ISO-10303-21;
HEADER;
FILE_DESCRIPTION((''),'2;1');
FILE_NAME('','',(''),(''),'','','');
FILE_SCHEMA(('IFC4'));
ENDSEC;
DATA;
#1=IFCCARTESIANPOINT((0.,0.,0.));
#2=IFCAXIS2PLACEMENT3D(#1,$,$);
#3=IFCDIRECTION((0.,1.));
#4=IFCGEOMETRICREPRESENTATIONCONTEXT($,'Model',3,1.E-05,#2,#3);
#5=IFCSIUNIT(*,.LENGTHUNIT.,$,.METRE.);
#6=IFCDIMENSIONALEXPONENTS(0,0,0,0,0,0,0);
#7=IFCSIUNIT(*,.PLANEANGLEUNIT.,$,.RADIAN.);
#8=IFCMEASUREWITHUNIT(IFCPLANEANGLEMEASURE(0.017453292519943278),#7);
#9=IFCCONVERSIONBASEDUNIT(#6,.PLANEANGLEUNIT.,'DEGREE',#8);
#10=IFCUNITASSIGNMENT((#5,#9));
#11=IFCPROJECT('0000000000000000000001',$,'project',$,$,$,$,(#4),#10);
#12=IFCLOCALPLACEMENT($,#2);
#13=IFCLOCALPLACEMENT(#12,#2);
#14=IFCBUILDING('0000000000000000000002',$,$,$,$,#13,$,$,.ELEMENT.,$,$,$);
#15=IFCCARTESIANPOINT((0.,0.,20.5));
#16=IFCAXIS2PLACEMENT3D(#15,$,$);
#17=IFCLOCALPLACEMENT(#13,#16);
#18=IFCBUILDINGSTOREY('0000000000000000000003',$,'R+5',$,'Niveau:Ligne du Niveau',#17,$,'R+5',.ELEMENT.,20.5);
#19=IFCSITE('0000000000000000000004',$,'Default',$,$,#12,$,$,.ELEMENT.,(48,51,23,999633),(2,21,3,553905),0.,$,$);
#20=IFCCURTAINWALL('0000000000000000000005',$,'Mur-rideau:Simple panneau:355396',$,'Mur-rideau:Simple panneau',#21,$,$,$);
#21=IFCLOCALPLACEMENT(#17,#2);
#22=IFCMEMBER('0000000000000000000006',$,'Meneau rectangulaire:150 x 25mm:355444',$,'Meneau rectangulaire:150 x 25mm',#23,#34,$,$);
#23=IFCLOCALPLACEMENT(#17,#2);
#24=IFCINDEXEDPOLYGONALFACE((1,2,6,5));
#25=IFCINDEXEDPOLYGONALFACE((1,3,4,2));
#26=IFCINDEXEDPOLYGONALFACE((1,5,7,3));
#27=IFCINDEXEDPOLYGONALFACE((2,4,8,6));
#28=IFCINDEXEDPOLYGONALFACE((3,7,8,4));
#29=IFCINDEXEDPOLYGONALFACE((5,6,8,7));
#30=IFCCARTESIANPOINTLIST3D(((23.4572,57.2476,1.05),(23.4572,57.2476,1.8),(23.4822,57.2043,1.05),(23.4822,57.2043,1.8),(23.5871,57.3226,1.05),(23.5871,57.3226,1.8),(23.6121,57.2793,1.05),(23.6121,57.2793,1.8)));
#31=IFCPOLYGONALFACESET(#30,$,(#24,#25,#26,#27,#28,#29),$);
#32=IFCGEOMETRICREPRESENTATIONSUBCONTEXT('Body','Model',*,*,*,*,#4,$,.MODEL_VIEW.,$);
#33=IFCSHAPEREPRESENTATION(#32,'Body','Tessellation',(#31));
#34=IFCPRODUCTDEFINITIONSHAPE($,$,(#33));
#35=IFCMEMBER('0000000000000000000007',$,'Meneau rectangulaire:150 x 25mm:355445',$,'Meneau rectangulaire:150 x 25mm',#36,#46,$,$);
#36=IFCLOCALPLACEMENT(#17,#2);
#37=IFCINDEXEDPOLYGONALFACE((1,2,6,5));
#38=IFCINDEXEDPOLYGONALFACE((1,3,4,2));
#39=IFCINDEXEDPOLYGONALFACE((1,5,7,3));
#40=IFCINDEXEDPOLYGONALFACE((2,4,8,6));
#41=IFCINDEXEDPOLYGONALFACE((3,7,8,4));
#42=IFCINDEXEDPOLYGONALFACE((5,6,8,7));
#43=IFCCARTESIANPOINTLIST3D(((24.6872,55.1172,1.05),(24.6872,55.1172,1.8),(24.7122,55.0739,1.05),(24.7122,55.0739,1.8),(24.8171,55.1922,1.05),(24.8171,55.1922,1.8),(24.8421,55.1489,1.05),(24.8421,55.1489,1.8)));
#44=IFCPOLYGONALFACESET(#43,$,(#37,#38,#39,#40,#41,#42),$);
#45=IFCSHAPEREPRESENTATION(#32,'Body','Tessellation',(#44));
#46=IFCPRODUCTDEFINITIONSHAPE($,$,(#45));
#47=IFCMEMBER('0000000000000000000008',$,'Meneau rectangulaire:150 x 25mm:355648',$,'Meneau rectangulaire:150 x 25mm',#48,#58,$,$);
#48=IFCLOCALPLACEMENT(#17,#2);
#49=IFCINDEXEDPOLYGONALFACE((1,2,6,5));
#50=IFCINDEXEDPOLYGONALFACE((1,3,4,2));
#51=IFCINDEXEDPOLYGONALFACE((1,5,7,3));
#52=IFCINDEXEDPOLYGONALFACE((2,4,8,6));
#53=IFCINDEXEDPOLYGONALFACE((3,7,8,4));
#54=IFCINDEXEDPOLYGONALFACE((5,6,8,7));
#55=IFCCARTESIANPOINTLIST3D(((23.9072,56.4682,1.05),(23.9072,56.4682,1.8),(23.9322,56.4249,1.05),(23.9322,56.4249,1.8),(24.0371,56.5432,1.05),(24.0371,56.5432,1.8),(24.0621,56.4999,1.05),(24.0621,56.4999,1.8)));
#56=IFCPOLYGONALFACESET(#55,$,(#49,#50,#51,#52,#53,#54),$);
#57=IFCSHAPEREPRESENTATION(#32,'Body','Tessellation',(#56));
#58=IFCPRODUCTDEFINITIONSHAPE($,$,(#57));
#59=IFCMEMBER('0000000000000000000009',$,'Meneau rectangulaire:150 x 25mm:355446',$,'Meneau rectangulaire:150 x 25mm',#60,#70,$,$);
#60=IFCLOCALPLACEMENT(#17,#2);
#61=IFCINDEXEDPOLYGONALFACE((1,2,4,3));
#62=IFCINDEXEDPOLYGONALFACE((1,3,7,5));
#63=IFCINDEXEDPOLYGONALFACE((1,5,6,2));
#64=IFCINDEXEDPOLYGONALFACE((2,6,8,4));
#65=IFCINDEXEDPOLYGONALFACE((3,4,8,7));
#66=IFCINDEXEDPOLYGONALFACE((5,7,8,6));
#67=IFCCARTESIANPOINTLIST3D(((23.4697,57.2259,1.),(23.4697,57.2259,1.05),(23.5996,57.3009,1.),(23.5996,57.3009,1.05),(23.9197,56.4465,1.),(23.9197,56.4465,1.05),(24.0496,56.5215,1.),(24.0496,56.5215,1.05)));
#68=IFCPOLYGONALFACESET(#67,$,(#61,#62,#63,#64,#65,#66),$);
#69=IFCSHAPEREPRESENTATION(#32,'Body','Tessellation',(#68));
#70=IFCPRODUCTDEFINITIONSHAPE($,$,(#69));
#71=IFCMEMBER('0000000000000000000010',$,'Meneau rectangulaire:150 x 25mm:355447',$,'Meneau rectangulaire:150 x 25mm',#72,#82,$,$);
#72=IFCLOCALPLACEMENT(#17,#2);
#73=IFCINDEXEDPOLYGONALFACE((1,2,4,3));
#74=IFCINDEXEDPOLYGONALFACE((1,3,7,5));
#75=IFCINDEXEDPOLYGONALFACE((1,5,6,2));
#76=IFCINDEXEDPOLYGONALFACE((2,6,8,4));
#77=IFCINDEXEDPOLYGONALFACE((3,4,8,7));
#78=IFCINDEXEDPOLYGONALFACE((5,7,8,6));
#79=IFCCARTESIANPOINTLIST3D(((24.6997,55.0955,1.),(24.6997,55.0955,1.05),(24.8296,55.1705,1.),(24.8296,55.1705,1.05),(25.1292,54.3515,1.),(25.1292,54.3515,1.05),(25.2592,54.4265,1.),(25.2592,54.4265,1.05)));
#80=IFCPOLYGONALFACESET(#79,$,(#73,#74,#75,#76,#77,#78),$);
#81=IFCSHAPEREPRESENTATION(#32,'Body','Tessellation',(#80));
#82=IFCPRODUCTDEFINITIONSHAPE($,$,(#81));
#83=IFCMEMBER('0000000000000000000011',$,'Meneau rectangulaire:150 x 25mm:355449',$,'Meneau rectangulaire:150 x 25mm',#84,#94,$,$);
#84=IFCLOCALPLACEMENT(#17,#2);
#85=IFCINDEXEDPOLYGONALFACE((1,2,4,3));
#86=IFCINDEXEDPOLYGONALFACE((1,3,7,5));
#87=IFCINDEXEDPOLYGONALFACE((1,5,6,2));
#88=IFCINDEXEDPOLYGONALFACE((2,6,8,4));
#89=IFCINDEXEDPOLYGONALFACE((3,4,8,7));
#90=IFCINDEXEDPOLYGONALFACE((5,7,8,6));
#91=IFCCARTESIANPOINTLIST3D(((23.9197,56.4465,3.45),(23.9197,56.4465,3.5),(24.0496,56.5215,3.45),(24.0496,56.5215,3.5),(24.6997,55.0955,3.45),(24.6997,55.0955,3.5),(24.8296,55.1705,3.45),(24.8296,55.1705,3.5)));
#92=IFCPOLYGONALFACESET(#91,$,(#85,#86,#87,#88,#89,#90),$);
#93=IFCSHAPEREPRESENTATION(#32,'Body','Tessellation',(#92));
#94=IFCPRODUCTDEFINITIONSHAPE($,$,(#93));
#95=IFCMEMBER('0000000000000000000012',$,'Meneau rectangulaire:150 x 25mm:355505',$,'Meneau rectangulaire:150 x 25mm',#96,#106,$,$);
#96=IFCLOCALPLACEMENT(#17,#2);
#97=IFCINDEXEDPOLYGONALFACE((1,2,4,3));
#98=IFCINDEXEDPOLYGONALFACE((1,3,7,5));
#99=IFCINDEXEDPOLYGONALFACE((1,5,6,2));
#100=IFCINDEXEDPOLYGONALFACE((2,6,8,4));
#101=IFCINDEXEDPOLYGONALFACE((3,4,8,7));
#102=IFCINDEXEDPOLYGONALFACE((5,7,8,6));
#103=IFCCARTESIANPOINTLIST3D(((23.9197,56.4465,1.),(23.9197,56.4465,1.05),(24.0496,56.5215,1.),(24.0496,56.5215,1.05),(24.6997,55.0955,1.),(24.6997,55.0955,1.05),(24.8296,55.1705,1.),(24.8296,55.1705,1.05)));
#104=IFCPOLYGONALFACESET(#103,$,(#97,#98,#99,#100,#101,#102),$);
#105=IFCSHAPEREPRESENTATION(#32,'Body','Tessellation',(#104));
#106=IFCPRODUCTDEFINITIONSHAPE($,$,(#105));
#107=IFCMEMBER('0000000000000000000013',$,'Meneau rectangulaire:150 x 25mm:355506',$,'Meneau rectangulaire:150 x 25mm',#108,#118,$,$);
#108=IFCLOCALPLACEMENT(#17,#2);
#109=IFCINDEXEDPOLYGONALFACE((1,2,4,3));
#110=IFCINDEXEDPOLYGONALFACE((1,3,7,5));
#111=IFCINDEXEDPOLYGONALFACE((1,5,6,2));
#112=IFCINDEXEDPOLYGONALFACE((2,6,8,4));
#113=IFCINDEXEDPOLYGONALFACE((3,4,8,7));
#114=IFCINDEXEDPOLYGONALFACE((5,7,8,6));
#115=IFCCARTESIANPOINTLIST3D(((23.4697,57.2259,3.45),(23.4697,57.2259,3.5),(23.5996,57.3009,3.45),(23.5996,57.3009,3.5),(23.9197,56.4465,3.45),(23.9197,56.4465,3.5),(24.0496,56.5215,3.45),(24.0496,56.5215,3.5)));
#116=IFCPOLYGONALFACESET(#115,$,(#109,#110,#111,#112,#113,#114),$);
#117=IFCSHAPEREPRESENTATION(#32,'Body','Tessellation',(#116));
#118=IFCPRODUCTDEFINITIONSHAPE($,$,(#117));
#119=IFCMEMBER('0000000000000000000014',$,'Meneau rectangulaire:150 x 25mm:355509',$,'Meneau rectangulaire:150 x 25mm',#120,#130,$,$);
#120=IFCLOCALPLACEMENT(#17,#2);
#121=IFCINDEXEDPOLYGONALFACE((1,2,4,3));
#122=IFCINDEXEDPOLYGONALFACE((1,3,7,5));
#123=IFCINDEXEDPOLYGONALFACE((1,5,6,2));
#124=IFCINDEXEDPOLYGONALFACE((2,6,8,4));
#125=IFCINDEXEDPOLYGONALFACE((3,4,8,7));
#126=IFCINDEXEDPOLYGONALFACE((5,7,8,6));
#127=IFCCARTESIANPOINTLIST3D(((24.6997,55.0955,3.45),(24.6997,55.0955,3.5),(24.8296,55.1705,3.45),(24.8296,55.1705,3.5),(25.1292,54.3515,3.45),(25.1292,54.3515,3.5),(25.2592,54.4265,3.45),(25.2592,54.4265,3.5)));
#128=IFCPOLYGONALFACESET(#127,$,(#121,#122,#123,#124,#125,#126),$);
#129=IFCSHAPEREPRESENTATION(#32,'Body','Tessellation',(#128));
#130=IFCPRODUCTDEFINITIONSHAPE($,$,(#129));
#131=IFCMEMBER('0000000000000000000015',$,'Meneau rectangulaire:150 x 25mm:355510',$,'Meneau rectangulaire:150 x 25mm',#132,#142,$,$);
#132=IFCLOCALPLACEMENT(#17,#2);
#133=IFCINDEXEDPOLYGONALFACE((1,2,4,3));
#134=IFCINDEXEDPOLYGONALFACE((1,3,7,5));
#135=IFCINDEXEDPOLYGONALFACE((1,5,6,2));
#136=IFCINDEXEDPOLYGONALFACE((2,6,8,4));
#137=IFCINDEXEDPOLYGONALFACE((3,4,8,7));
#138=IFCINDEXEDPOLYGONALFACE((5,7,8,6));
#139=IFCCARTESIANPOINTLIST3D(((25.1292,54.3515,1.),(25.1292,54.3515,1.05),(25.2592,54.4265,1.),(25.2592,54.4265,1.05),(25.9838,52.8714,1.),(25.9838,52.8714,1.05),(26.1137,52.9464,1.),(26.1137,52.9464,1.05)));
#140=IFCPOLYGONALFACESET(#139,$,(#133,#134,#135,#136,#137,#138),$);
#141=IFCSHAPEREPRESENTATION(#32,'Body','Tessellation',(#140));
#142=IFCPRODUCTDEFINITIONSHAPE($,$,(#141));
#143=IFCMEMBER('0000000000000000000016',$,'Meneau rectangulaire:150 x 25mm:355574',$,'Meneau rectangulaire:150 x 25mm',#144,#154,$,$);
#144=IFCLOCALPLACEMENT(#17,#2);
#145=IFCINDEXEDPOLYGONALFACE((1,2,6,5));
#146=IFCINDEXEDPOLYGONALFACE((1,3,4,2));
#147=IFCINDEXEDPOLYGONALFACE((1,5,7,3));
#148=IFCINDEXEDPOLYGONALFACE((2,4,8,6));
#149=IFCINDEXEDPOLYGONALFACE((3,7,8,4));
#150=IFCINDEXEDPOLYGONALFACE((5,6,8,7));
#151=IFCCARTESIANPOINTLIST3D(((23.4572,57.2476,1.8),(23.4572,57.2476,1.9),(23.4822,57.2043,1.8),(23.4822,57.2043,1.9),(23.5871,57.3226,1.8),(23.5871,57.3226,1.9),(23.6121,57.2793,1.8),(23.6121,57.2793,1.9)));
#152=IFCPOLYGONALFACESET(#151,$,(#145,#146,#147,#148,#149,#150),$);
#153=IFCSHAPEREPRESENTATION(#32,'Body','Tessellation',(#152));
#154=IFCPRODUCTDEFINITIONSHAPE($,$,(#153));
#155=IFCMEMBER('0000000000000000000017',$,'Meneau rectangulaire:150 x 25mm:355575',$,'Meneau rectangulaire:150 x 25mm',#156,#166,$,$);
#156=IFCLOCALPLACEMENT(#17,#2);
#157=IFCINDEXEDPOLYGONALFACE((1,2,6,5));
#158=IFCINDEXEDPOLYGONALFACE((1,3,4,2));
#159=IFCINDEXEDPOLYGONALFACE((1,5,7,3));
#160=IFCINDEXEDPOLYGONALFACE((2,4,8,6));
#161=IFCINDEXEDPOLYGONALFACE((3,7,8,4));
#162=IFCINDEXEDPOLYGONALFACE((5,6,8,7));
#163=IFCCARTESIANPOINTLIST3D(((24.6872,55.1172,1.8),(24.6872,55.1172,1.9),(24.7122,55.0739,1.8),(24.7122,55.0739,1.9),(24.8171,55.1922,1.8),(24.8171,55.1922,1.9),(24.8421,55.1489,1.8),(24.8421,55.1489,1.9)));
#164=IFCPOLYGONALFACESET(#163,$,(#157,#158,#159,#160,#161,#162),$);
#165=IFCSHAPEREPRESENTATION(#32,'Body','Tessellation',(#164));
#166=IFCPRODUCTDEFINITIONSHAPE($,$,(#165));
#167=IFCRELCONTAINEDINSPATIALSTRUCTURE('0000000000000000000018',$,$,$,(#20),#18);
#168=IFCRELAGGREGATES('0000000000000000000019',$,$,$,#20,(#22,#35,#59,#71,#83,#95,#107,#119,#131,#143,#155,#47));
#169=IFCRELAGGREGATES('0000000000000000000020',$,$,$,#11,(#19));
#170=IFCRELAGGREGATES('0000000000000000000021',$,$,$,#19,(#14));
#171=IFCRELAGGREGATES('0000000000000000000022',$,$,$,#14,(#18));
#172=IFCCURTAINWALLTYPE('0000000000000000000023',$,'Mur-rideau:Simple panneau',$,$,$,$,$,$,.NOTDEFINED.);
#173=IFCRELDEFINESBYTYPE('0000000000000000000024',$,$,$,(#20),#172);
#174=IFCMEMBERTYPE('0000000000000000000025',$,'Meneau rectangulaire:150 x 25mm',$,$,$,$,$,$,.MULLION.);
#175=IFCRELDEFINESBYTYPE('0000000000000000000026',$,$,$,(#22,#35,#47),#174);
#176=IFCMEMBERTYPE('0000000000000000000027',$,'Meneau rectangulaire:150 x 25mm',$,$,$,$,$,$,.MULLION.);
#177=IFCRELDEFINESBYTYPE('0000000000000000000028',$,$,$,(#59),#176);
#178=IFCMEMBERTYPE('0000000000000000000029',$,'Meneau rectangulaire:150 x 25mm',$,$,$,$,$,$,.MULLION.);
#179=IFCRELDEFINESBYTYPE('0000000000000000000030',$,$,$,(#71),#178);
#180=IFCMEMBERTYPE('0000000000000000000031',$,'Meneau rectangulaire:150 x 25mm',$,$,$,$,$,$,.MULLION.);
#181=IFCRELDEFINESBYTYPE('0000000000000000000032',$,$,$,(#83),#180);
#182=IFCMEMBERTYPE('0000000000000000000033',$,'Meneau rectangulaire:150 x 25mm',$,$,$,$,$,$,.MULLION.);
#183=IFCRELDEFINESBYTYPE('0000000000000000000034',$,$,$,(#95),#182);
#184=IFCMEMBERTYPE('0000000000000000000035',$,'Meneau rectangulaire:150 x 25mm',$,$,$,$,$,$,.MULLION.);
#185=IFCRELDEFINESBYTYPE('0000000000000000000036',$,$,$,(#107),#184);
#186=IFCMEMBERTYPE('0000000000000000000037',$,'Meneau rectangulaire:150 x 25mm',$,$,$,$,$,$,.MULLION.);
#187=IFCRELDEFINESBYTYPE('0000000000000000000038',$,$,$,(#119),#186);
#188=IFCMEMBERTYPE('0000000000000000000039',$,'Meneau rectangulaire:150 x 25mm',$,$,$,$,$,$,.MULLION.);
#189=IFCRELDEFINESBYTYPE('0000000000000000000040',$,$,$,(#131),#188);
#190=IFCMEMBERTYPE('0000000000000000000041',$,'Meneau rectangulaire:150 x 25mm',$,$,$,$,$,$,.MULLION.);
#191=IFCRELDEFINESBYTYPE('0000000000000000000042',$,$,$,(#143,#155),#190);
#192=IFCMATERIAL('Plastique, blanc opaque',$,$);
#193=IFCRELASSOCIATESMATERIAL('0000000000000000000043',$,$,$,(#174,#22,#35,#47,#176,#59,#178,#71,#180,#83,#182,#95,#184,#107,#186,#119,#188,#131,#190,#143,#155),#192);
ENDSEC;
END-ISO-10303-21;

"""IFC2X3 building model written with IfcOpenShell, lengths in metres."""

from ifc_helpers import new_model, entity, si_unit, converted_unit, direction, frame, origin, origin_2d_with_axis, place, context, subcontext, project, spatial, rectangle, extrude, source, transform, mapped, material, type_object, type_shapes, element, aggregate, save


model = new_model("IFC2X3")

# Units and contexts
model_context = context("Model", 3, precision=1e-05, world=origin(), true_north=direction((0.0, 1.0)))
body_context = subcontext(model_context, "Body", "Model", "MODEL_VIEW")
ifc_project = project(units=[si_unit("LENGTHUNIT", "METRE"), converted_unit("PLANEANGLEUNIT", "DEGREE", entity("IfcPlaneAngleMeasure", 0.017453292519943278), si_unit("PLANEANGLEUNIT", "RADIAN"), dimensions=[0, 0, 0, 0, 0, 0, 0])], contexts=[model_context])

# Site, building, storey
site_placement = place(None, origin())
site = spatial("IfcSite", under=ifc_project, at=site_placement, Name="Default", CompositionType="ELEMENT", RefLatitude=(48, 51, 23, 999633), RefLongitude=(2, 21, 3, 553905), RefElevation=0.0)
building_placement = place(site_placement, origin())
building = spatial("IfcBuilding", under=site, at=building_placement, CompositionType="ELEMENT")
storey_placement = place(building_placement, frame((0.0, 0.0, 20.5)))
storey = spatial("IfcBuildingStorey", under=building, at=storey_placement, Name="R+5", ObjectType="Niveau:Ligne du Niveau", LongName="R+5", CompositionType="ELEMENT", Elevation=20.5)

# Curtain wall, members
curtain_wall_type = type_object("IfcCurtainWallType", Name="Mur-rideau:Simple panneau", PredefinedType="NOTDEFINED")
curtain_wall_placement = place(storey_placement, frame((0.0, 0.0, -20.5)))
curtain_wall = element("IfcCurtainWall", 1, at=curtain_wall_placement, inside=storey, type_object=curtain_wall_type, Name="Mur-rideau:Simple panneau:355396", ObjectType="Mur-rideau:Simple panneau")
ifc_material_1 = material(Name="Plastique, blanc opaque")
member_type_1 = type_object("IfcMemberType", Name="Meneau rectangulaire:150 x 25mm", PredefinedType="MULLION", material=ifc_material_1)
shared_shape_1 = source(origin(), body_context, "Body", "SweptSolid", [
    extrude(rectangle(XDim=0.05, YDim=0.15, at=origin_2d_with_axis()), frame((0.0, 0.0, -0.75), z_axis=(0.0, 0.0, 1.0), x_axis=(-1.0, 0.0, 0.0)), (0.0, 0.0, 1.0), 0.75),
])
type_shapes(member_type_1, [shared_shape_1])
member_1_placement = place(curtain_wall_placement, frame((23.5346, 57.2634, 21.55), z_axis=(0.0, 0.0, -1.0), x_axis=(0.5, -0.866025, 0.0)))
member_1 = element("IfcMember", 2, at=member_1_placement, type_object=member_type_1, material=ifc_material_1, Name="Meneau rectangulaire:150 x 25mm:355444", ObjectType="Meneau rectangulaire:150 x 25mm", context=body_context, shape_type="MappedRepresentation", body=[
    mapped(shared_shape_1, transform((0.0, 0.0, 0.0), scale=1.0)),
])
member_2_placement = place(curtain_wall_placement, frame((24.7646, 55.133, 21.55), z_axis=(0.0, 0.0, -1.0), x_axis=(0.5, -0.866025, 0.0)))
member_2 = element("IfcMember", 3, at=member_2_placement, type_object=member_type_1, material=ifc_material_1, Name="Meneau rectangulaire:150 x 25mm:355445", ObjectType="Meneau rectangulaire:150 x 25mm", context=body_context, shape_type="MappedRepresentation", body=[
    mapped(shared_shape_1, transform((0.0, 0.0, 0.0), scale=1.0)),
])
member_3_placement = place(curtain_wall_placement, frame((23.9846, 56.484, 21.55), z_axis=(0.0, 0.0, -1.0), x_axis=(0.5, -0.866025, 0.0)))
member_3 = element("IfcMember", 4, at=member_3_placement, type_object=member_type_1, material=ifc_material_1, Name="Meneau rectangulaire:150 x 25mm:355648", ObjectType="Meneau rectangulaire:150 x 25mm", context=body_context, shape_type="MappedRepresentation", body=[
    mapped(shared_shape_1, transform((0.0, 0.0, 0.0), scale=1.0)),
])
member_type_2 = type_object("IfcMemberType", Name="Meneau rectangulaire:150 x 25mm", PredefinedType="MULLION", material=ifc_material_1)
shared_shape_2 = source(origin(), body_context, "Body", "SweptSolid", [
    extrude(rectangle(XDim=0.05, YDim=0.15, at=origin_2d_with_axis()), frame((-0.025, 0.0, -0.9), z_axis=(0.0, 0.0, 1.0), x_axis=(-1.0, 0.0, 0.0)), (0.0, 0.0, 1.0), 0.9),
])
type_shapes(member_type_2, [shared_shape_2])
member_4_placement = place(curtain_wall_placement, frame((23.5346, 57.2634, 21.5), z_axis=(-0.5, 0.866025, 0.0), x_axis=(0.0, 0.0, -1.0)))
member_4 = element("IfcMember", 5, at=member_4_placement, type_object=member_type_2, material=ifc_material_1, Name="Meneau rectangulaire:150 x 25mm:355446", ObjectType="Meneau rectangulaire:150 x 25mm", context=body_context, shape_type="MappedRepresentation", body=[
    mapped(shared_shape_2, transform((0.0, 0.0, 0.0), scale=1.0)),
])
member_type_3 = type_object("IfcMemberType", Name="Meneau rectangulaire:150 x 25mm", PredefinedType="MULLION", material=ifc_material_1)
shared_shape_3 = source(origin(), body_context, "Body", "SweptSolid", [
    extrude(rectangle(XDim=0.05, YDim=0.15, at=origin_2d_with_axis()), frame((-0.025, 0.0, -0.8591), z_axis=(0.0, 0.0, 1.0), x_axis=(-1.0, 0.0, 0.0)), (0.0, 0.0, 1.0), 0.8591),
])
type_shapes(member_type_3, [shared_shape_3])
member_5_placement = place(curtain_wall_placement, frame((24.7646, 55.133, 21.5), z_axis=(-0.5, 0.866025, 0.0), x_axis=(0.0, 0.0, -1.0)))
member_5 = element("IfcMember", 6, at=member_5_placement, type_object=member_type_3, material=ifc_material_1, Name="Meneau rectangulaire:150 x 25mm:355447", ObjectType="Meneau rectangulaire:150 x 25mm", context=body_context, shape_type="MappedRepresentation", body=[
    mapped(shared_shape_3, transform((0.0, 0.0, 0.0), scale=1.0)),
])
member_type_4 = type_object("IfcMemberType", Name="Meneau rectangulaire:150 x 25mm", PredefinedType="MULLION", material=ifc_material_1)
shared_shape_4 = source(origin(), body_context, "Body", "SweptSolid", [
    extrude(rectangle(XDim=0.05, YDim=0.15, at=origin_2d_with_axis()), frame((-0.025, 0.0, -1.56), z_axis=(0.0, 0.0, 1.0), x_axis=(-1.0, 0.0, 0.0)), (0.0, 0.0, 1.0), 1.56),
])
type_shapes(member_type_4, [shared_shape_4])
member_6_placement = place(curtain_wall_placement, frame((24.7646, 55.133, 24.0), z_axis=(0.5, -0.866025, 0.0), x_axis=(0.0, 0.0, 1.0)))
member_6 = element("IfcMember", 7, at=member_6_placement, type_object=member_type_4, material=ifc_material_1, Name="Meneau rectangulaire:150 x 25mm:355449", ObjectType="Meneau rectangulaire:150 x 25mm", context=body_context, shape_type="MappedRepresentation", body=[
    mapped(shared_shape_4, transform((0.0, 0.0, 0.0), scale=1.0)),
])
member_type_5 = type_object("IfcMemberType", Name="Meneau rectangulaire:150 x 25mm", PredefinedType="MULLION", material=ifc_material_1)
shared_shape_5 = source(origin(), body_context, "Body", "SweptSolid", [
    extrude(rectangle(XDim=0.05, YDim=0.15, at=origin_2d_with_axis()), frame((-0.025, 0.0, -1.56), z_axis=(0.0, 0.0, 1.0), x_axis=(-1.0, 0.0, 0.0)), (0.0, 0.0, 1.0), 1.56),
])
type_shapes(member_type_5, [shared_shape_5])
member_7_placement = place(curtain_wall_placement, frame((23.9846, 56.484, 21.5), z_axis=(-0.5, 0.866025, 0.0), x_axis=(0.0, 0.0, -1.0)))
member_7 = element("IfcMember", 8, at=member_7_placement, type_object=member_type_5, material=ifc_material_1, Name="Meneau rectangulaire:150 x 25mm:355505", ObjectType="Meneau rectangulaire:150 x 25mm", context=body_context, shape_type="MappedRepresentation", body=[
    mapped(shared_shape_5, transform((0.0, 0.0, 0.0), scale=1.0)),
])
member_type_6 = type_object("IfcMemberType", Name="Meneau rectangulaire:150 x 25mm", PredefinedType="MULLION", material=ifc_material_1)
shared_shape_6 = source(origin(), body_context, "Body", "SweptSolid", [
    extrude(rectangle(XDim=0.05, YDim=0.15, at=origin_2d_with_axis()), frame((-0.025, 0.0, -0.9), z_axis=(0.0, 0.0, 1.0), x_axis=(-1.0, 0.0, 0.0)), (0.0, 0.0, 1.0), 0.9),
])
type_shapes(member_type_6, [shared_shape_6])
member_8_placement = place(curtain_wall_placement, frame((23.9846, 56.484, 24.0), z_axis=(0.5, -0.866025, 0.0), x_axis=(0.0, 0.0, 1.0)))
member_8 = element("IfcMember", 9, at=member_8_placement, type_object=member_type_6, material=ifc_material_1, Name="Meneau rectangulaire:150 x 25mm:355506", ObjectType="Meneau rectangulaire:150 x 25mm", context=body_context, shape_type="MappedRepresentation", body=[
    mapped(shared_shape_6, transform((0.0, 0.0, 0.0), scale=1.0)),
])
member_type_7 = type_object("IfcMemberType", Name="Meneau rectangulaire:150 x 25mm", PredefinedType="MULLION", material=ifc_material_1)
shared_shape_7 = source(origin(), body_context, "Body", "SweptSolid", [
    extrude(rectangle(XDim=0.05, YDim=0.15, at=origin_2d_with_axis()), frame((-0.025, 0.0, -0.8591), z_axis=(0.0, 0.0, 1.0), x_axis=(-1.0, 0.0, 0.0)), (0.0, 0.0, 1.0), 0.8591),
])
type_shapes(member_type_7, [shared_shape_7])
member_9_placement = place(curtain_wall_placement, frame((25.1942, 54.389, 24.0), z_axis=(0.5, -0.866025, 0.0), x_axis=(0.0, 0.0, 1.0)))
member_9 = element("IfcMember", 10, at=member_9_placement, type_object=member_type_7, material=ifc_material_1, Name="Meneau rectangulaire:150 x 25mm:355509", ObjectType="Meneau rectangulaire:150 x 25mm", context=body_context, shape_type="MappedRepresentation", body=[
    mapped(shared_shape_7, transform((0.0, 0.0, 0.0), scale=1.0)),
])
member_type_8 = type_object("IfcMemberType", Name="Meneau rectangulaire:150 x 25mm", PredefinedType="MULLION", material=ifc_material_1)
shared_shape_8 = source(origin(), body_context, "Body", "SweptSolid", [
    extrude(rectangle(XDim=0.05, YDim=0.15, at=origin_2d_with_axis()), frame((-0.025, 0.0, -1.709), z_axis=(0.0, 0.0, 1.0), x_axis=(-1.0, 0.0, 0.0)), (0.0, 0.0, 1.0), 1.709),
])
type_shapes(member_type_8, [shared_shape_8])
member_10_placement = place(curtain_wall_placement, frame((25.1942, 54.389, 21.5), z_axis=(-0.5, 0.866025, 0.0), x_axis=(0.0, 0.0, -1.0)))
member_10 = element("IfcMember", 11, at=member_10_placement, type_object=member_type_8, material=ifc_material_1, Name="Meneau rectangulaire:150 x 25mm:355510", ObjectType="Meneau rectangulaire:150 x 25mm", context=body_context, shape_type="MappedRepresentation", body=[
    mapped(shared_shape_8, transform((0.0, 0.0, 0.0), scale=1.0)),
])
member_type_9 = type_object("IfcMemberType", Name="Meneau rectangulaire:150 x 25mm", PredefinedType="MULLION", material=ifc_material_1)
shared_shape_9 = source(origin(), body_context, "Body", "SweptSolid", [
    extrude(rectangle(XDim=0.05, YDim=0.15, at=origin_2d_with_axis()), frame((0.0, 0.0, -0.1), z_axis=(0.0, 0.0, 1.0), x_axis=(-1.0, 0.0, 0.0)), (0.0, 0.0, 1.0), 0.1),
])
type_shapes(member_type_9, [shared_shape_9])
member_11_placement = place(curtain_wall_placement, frame((23.5346, 57.2634, 22.3), z_axis=(0.0, 0.0, -1.0), x_axis=(0.5, -0.866025, 0.0)))
member_11 = element("IfcMember", 12, at=member_11_placement, type_object=member_type_9, material=ifc_material_1, Name="Meneau rectangulaire:150 x 25mm:355574", ObjectType="Meneau rectangulaire:150 x 25mm", context=body_context, shape_type="MappedRepresentation", body=[
    mapped(shared_shape_9, transform((0.0, 0.0, 0.0), scale=1.0)),
])
member_12_placement = place(curtain_wall_placement, frame((24.7646, 55.133, 22.3), z_axis=(0.0, 0.0, -1.0), x_axis=(0.5, -0.866025, 0.0)))
member_12 = element("IfcMember", 13, at=member_12_placement, type_object=member_type_9, material=ifc_material_1, Name="Meneau rectangulaire:150 x 25mm:355575", ObjectType="Meneau rectangulaire:150 x 25mm", context=body_context, shape_type="MappedRepresentation", body=[
    mapped(shared_shape_9, transform((0.0, 0.0, 0.0), scale=1.0)),
])
aggregate(curtain_wall, [member_1, member_2, member_4, member_5, member_6, member_7, member_8, member_9, member_10, member_11, member_12, member_3])

save(model, "model.ifc")
